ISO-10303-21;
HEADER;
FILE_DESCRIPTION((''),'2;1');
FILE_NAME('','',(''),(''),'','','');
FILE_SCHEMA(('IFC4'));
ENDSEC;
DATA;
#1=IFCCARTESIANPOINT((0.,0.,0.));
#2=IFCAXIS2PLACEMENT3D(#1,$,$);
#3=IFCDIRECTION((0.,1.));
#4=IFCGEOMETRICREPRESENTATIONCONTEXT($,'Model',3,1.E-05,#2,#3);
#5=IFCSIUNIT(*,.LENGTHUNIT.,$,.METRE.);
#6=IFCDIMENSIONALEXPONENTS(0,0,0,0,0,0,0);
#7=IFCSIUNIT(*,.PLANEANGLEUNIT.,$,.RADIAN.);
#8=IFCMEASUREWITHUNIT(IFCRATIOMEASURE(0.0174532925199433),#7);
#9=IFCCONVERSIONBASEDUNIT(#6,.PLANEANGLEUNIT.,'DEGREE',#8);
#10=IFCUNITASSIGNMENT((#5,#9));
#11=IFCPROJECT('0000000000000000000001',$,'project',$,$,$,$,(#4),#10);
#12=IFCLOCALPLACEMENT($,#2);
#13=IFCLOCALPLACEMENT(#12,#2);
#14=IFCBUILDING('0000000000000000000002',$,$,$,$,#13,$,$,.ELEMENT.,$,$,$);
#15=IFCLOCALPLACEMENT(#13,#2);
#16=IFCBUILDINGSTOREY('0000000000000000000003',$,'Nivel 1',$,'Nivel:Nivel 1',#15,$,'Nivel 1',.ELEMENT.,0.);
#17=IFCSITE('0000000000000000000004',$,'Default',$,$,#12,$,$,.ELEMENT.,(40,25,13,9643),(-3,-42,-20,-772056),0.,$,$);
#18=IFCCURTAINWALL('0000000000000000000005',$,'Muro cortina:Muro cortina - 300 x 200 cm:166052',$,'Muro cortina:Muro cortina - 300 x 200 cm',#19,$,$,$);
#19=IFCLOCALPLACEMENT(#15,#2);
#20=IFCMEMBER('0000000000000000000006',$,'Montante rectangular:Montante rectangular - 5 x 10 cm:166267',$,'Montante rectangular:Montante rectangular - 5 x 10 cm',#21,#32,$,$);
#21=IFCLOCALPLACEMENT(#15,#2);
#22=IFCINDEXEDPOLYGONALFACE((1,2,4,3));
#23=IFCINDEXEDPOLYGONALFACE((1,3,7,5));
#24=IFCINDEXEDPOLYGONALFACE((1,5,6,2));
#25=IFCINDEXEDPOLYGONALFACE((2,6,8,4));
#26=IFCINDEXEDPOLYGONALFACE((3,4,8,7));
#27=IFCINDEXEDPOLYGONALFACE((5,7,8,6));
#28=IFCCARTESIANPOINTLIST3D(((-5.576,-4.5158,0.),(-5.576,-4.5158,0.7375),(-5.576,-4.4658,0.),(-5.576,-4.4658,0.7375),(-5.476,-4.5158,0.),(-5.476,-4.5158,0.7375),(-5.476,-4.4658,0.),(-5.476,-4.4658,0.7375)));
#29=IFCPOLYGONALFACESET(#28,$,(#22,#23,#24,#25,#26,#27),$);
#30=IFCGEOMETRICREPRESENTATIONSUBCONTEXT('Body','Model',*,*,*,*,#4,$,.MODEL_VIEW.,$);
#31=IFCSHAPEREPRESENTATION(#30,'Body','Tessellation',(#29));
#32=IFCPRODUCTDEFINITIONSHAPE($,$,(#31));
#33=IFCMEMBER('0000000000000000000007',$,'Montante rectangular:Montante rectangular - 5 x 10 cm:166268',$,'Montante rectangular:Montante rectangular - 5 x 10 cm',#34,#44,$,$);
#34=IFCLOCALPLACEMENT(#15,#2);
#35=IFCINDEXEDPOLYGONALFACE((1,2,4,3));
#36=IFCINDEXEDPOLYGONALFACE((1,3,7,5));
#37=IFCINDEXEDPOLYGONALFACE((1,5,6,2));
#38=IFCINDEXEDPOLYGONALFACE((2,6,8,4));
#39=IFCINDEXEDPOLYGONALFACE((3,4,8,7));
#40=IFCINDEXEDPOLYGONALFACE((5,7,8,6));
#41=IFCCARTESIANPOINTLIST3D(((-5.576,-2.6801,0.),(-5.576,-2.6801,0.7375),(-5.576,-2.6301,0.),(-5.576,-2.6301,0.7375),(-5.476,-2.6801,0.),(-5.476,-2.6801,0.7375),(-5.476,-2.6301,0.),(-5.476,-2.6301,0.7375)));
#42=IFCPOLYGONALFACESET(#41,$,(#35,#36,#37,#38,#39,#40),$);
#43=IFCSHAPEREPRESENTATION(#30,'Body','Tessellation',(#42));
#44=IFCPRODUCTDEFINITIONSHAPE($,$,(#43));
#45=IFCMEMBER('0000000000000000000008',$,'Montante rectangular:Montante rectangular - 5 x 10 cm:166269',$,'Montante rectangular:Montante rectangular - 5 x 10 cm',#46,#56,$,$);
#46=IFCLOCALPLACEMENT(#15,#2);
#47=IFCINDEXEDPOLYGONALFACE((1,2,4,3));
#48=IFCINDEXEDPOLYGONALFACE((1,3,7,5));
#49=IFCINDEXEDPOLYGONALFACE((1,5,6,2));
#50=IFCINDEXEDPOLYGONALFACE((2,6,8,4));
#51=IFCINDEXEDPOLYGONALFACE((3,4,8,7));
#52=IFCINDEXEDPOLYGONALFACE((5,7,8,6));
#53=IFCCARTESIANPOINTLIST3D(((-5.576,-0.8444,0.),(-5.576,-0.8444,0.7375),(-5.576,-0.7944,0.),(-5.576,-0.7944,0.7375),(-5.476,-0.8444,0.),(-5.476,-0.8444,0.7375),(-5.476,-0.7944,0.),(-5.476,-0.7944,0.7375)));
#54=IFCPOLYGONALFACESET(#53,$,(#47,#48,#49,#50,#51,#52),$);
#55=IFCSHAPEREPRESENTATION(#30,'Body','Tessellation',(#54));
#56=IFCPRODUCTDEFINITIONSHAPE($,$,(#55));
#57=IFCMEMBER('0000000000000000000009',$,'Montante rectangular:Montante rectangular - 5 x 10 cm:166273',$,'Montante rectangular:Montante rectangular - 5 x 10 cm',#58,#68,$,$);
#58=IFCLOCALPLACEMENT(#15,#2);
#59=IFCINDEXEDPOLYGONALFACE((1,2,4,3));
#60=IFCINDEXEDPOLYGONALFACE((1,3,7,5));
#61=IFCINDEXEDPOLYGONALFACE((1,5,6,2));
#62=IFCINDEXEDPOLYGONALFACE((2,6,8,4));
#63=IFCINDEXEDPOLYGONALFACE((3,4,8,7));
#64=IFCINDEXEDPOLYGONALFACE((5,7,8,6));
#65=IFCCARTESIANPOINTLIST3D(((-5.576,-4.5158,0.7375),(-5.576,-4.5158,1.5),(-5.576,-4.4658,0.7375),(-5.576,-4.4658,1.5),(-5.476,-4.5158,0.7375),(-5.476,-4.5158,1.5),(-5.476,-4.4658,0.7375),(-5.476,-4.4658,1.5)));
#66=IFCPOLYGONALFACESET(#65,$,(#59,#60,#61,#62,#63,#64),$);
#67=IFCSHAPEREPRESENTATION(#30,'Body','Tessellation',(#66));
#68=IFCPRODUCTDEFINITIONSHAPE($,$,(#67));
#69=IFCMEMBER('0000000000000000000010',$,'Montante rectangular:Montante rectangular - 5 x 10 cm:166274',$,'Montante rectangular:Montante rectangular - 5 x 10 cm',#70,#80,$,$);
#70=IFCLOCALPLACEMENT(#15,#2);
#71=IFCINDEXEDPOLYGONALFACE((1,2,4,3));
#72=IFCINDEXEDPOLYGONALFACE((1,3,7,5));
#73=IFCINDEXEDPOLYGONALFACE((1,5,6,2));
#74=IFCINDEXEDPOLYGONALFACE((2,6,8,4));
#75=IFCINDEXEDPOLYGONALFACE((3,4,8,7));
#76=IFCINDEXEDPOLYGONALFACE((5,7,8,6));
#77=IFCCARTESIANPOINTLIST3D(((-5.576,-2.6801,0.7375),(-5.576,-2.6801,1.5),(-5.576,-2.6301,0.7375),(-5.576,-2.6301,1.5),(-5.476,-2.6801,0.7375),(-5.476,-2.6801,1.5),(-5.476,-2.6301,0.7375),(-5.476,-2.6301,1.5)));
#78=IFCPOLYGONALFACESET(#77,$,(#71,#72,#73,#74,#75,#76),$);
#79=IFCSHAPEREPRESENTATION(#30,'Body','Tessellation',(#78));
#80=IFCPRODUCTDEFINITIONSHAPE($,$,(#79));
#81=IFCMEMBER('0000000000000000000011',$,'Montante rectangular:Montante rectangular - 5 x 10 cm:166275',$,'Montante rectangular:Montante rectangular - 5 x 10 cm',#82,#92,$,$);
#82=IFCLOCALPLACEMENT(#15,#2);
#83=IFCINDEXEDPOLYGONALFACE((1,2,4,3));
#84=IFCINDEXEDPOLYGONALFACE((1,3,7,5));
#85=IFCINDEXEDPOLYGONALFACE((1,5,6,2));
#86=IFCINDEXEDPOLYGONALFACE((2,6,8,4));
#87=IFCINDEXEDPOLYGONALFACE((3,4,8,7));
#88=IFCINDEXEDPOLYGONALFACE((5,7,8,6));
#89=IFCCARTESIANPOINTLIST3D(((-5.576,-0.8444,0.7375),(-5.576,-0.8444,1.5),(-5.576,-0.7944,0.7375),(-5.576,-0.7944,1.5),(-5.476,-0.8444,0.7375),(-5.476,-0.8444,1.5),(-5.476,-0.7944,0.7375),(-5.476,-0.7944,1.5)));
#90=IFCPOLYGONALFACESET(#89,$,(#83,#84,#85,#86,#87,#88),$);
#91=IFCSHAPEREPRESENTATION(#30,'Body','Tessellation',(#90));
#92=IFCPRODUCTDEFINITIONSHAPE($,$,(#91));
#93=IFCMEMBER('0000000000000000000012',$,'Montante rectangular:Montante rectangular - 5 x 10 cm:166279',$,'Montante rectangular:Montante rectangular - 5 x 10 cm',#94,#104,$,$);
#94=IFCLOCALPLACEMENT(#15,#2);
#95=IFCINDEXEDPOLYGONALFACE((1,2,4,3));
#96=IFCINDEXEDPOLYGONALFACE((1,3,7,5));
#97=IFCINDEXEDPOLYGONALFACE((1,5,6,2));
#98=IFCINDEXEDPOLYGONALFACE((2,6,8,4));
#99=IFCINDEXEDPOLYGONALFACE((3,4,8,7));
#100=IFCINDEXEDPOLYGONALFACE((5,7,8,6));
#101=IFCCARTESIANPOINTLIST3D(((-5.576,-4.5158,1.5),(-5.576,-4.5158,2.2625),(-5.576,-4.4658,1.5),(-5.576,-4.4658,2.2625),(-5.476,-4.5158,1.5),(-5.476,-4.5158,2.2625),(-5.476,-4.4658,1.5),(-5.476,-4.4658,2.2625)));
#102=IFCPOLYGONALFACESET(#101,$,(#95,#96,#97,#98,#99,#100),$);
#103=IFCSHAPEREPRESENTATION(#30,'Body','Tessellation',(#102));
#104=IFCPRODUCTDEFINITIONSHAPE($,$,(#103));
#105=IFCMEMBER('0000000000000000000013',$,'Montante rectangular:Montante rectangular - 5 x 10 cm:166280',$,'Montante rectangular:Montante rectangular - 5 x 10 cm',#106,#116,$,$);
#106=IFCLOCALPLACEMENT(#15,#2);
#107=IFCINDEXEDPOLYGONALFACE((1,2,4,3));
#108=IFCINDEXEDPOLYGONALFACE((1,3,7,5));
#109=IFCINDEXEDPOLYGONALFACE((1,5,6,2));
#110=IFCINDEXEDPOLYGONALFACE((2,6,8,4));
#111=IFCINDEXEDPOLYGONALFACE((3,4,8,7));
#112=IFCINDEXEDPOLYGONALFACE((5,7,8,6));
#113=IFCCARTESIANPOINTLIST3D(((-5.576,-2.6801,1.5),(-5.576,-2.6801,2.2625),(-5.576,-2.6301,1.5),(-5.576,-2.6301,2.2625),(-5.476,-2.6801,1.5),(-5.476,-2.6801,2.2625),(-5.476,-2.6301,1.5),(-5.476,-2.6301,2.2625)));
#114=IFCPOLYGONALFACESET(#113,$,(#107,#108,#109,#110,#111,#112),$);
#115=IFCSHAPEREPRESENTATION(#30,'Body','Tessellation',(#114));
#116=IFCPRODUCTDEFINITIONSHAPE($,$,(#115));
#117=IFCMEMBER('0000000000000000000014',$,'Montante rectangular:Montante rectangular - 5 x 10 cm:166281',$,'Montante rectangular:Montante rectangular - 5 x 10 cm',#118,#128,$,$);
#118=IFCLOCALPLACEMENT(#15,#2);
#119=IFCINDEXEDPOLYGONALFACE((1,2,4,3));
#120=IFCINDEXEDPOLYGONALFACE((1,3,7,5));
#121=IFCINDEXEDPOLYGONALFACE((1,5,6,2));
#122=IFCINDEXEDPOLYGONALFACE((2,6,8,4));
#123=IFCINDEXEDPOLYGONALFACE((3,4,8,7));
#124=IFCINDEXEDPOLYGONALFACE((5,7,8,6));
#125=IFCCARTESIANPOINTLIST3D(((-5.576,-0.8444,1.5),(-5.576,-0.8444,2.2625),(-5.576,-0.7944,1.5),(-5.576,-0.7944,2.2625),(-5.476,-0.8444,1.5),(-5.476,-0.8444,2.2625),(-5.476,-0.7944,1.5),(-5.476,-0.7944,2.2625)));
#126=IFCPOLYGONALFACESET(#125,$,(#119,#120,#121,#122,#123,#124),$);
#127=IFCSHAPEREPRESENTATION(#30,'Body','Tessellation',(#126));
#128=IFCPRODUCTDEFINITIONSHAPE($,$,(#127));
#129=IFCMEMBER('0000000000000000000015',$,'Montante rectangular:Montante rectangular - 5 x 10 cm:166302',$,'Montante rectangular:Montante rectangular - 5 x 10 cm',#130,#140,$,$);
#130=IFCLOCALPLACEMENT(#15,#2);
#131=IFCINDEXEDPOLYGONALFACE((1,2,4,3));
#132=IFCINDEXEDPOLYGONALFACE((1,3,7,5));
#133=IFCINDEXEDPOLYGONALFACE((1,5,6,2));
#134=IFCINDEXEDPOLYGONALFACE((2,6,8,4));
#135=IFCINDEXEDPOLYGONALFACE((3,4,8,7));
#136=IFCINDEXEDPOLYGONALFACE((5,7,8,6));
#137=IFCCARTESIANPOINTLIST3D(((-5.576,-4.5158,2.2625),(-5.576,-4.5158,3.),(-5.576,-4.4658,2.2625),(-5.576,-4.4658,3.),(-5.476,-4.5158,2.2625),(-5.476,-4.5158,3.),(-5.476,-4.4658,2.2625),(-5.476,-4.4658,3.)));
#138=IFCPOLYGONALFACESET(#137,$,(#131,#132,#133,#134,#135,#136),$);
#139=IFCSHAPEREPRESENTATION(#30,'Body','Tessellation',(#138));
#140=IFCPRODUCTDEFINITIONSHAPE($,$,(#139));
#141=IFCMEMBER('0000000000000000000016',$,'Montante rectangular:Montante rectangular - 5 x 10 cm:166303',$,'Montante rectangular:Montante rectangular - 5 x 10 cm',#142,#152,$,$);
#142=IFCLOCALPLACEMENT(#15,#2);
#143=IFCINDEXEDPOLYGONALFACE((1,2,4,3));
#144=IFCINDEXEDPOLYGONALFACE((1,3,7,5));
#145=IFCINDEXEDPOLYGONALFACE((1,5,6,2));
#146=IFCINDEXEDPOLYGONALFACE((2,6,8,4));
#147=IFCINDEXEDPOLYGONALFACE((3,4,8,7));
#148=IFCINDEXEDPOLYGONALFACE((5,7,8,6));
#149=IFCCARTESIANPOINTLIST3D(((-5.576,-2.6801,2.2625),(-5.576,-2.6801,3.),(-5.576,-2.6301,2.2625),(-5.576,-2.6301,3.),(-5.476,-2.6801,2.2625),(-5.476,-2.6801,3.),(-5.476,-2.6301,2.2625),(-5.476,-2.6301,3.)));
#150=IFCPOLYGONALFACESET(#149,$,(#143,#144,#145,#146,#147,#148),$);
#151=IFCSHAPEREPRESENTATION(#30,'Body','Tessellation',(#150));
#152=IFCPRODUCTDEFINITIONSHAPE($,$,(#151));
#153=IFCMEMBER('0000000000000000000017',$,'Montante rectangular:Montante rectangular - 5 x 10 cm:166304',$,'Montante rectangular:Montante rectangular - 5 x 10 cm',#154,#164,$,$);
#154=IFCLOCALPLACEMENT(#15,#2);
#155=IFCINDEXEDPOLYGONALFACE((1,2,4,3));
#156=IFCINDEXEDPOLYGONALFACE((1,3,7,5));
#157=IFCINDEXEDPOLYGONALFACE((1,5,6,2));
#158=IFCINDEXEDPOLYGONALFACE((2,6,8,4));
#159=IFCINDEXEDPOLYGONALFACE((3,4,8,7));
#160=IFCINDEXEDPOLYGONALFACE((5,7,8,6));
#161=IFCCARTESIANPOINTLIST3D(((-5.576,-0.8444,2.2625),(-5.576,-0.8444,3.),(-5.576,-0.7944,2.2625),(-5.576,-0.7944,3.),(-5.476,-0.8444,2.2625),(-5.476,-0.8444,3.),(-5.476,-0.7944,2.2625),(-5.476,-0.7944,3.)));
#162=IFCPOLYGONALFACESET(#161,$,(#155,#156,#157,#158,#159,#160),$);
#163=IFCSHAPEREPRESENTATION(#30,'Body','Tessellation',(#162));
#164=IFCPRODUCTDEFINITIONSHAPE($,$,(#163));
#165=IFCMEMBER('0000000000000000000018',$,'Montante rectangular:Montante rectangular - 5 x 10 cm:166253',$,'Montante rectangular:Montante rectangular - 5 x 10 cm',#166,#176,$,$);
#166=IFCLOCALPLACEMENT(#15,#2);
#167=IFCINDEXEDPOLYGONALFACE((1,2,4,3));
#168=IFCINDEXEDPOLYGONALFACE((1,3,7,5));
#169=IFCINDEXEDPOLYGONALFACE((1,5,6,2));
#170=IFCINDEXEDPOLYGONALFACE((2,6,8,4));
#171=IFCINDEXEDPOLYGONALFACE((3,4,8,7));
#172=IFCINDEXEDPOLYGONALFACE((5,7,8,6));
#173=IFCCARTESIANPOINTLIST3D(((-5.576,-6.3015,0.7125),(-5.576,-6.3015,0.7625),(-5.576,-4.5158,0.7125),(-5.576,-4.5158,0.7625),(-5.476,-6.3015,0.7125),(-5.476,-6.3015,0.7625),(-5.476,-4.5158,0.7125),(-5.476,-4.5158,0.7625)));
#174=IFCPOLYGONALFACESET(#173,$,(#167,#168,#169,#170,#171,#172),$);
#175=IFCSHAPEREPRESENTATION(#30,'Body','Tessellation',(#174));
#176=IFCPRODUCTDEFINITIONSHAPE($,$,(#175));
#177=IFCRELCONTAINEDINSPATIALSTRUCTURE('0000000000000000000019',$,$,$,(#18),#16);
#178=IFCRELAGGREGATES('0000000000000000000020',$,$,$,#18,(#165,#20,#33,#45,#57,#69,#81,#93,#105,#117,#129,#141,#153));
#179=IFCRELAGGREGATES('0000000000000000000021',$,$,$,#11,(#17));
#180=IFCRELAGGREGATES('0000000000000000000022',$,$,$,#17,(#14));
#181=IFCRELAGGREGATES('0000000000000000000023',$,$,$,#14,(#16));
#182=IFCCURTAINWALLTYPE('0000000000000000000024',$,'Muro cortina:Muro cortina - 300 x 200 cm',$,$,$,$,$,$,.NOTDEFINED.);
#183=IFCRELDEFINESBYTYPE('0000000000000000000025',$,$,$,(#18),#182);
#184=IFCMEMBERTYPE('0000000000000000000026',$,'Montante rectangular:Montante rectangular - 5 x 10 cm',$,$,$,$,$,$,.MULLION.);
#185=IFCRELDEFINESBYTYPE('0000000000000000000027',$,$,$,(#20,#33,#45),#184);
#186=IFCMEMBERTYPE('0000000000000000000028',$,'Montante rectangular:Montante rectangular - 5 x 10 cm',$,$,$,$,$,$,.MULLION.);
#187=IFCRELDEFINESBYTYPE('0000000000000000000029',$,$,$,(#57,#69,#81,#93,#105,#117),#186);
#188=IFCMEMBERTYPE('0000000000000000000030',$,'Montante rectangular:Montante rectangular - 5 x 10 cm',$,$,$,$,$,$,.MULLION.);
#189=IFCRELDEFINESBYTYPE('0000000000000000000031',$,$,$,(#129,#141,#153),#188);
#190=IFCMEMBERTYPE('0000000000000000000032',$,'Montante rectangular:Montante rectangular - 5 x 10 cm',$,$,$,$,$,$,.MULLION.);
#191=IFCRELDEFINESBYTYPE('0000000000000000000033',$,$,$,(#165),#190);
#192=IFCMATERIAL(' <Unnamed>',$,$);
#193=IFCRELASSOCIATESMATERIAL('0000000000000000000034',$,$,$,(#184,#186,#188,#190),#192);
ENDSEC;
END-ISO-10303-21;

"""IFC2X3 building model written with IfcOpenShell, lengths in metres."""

from ifc_helpers import new_model, entity, si_unit, converted_unit, direction, frame, origin, origin_2d_with_axis, place, context, subcontext, project, spatial, rectangle, extrude, source, transform, mapped, material, type_object, type_shapes, element, aggregate, save


model = new_model("IFC2X3")

# Units and contexts
model_context = context("Model", 3, precision=1e-05, world=origin(), true_north=direction((0.0, 1.0)))
body_context = subcontext(model_context, "Body", "Model", "MODEL_VIEW")
ifc_project = project(units=[si_unit("LENGTHUNIT", "METRE"), converted_unit("PLANEANGLEUNIT", "DEGREE", entity("IfcRatioMeasure", 0.0174532925199433), si_unit("PLANEANGLEUNIT", "RADIAN"), dimensions=[0, 0, 0, 0, 0, 0, 0])], contexts=[model_context])

# Site, building, storey
site_placement = place(None, origin())
site = spatial("IfcSite", under=ifc_project, at=site_placement, Name="Default", CompositionType="ELEMENT", RefLatitude=(40, 25, 13, 9643), RefLongitude=(-3, -42, -20, -772056), RefElevation=0.0)
building_placement = place(site_placement, origin())
building = spatial("IfcBuilding", under=site, at=building_placement, CompositionType="ELEMENT")
storey_placement = place(building_placement, origin())
storey = spatial("IfcBuildingStorey", under=building, at=storey_placement, Name="Nivel 1", ObjectType="Nivel:Nivel 1", LongName="Nivel 1", CompositionType="ELEMENT", Elevation=0.0)

# Curtain wall, members
curtain_wall_type = type_object("IfcCurtainWallType", Name="Muro cortina:Muro cortina - 300 x 200 cm", PredefinedType="NOTDEFINED")
curtain_wall_placement = place(storey_placement, origin())
curtain_wall = element("IfcCurtainWall", 1, at=curtain_wall_placement, inside=storey, type_object=curtain_wall_type, Name="Muro cortina:Muro cortina - 300 x 200 cm:166052", ObjectType="Muro cortina:Muro cortina - 300 x 200 cm")
ifc_material_1 = material(Name=" <Unnamed>")
member_type_1 = type_object("IfcMemberType", Name="Montante rectangular:Montante rectangular - 5 x 10 cm", PredefinedType="MULLION", material=ifc_material_1)
shared_shape_1 = source(origin(), body_context, "Body", "SweptSolid", [
    extrude(rectangle(XDim=0.1, YDim=0.05, at=origin_2d_with_axis()), frame((0.0, 0.0, -0.7375), z_axis=(0.0, 0.0, 1.0), x_axis=(0.0, -1.0, 0.0)), (0.0, 0.0, 1.0), 0.7375),
])
type_shapes(member_type_1, [shared_shape_1])
member_1_placement = place(storey_placement, frame((-5.526, -4.4908, 0.0), z_axis=(0.0, 0.0, -1.0), x_axis=(0.0, 1.0, 0.0)))
member_1 = element("IfcMember", 2, at=member_1_placement, type_object=member_type_1, Name="Montante rectangular:Montante rectangular - 5 x 10 cm:166267", ObjectType="Montante rectangular:Montante rectangular - 5 x 10 cm", context=body_context, shape_type="MappedRepresentation", body=[
    mapped(shared_shape_1, transform((0.0, 0.0, 0.0), scale=1.0)),
])
member_2_placement = place(storey_placement, frame((-5.526, -2.6551, 0.0), z_axis=(0.0, 0.0, -1.0), x_axis=(0.0, 1.0, 0.0)))
member_2 = element("IfcMember", 3, at=member_2_placement, type_object=member_type_1, Name="Montante rectangular:Montante rectangular - 5 x 10 cm:166268", ObjectType="Montante rectangular:Montante rectangular - 5 x 10 cm", context=body_context, shape_type="MappedRepresentation", body=[
    mapped(shared_shape_1, transform((0.0, 0.0, 0.0), scale=1.0)),
])
member_3_placement = place(storey_placement, frame((-5.526, -0.8194, 0.0), z_axis=(0.0, 0.0, -1.0), x_axis=(0.0, 1.0, 0.0)))
member_3 = element("IfcMember", 4, at=member_3_placement, type_object=member_type_1, Name="Montante rectangular:Montante rectangular - 5 x 10 cm:166269", ObjectType="Montante rectangular:Montante rectangular - 5 x 10 cm", context=body_context, shape_type="MappedRepresentation", body=[
    mapped(shared_shape_1, transform((0.0, 0.0, 0.0), scale=1.0)),
])
member_type_2 = type_object("IfcMemberType", Name="Montante rectangular:Montante rectangular - 5 x 10 cm", PredefinedType="MULLION", material=ifc_material_1)
shared_shape_2 = source(origin(), body_context, "Body", "SweptSolid", [
    extrude(rectangle(XDim=0.1, YDim=0.05, at=origin_2d_with_axis()), frame((0.0, 0.0, -0.7625), z_axis=(0.0, 0.0, 1.0), x_axis=(0.0, -1.0, 0.0)), (0.0, 0.0, 1.0), 0.7625),
])
type_shapes(member_type_2, [shared_shape_2])
member_4_placement = place(storey_placement, frame((-5.526, -4.4908, 0.7375), z_axis=(0.0, 0.0, -1.0), x_axis=(0.0, 1.0, 0.0)))
member_4 = element("IfcMember", 5, at=member_4_placement, type_object=member_type_2, Name="Montante rectangular:Montante rectangular - 5 x 10 cm:166273", ObjectType="Montante rectangular:Montante rectangular - 5 x 10 cm", context=body_context, shape_type="MappedRepresentation", body=[
    mapped(shared_shape_2, transform((0.0, 0.0, 0.0), scale=1.0)),
])
member_5_placement = place(storey_placement, frame((-5.526, -2.6551, 0.7375), z_axis=(0.0, 0.0, -1.0), x_axis=(0.0, 1.0, 0.0)))
member_5 = element("IfcMember", 6, at=member_5_placement, type_object=member_type_2, Name="Montante rectangular:Montante rectangular - 5 x 10 cm:166274", ObjectType="Montante rectangular:Montante rectangular - 5 x 10 cm", context=body_context, shape_type="MappedRepresentation", body=[
    mapped(shared_shape_2, transform((0.0, 0.0, 0.0), scale=1.0)),
])
member_6_placement = place(storey_placement, frame((-5.526, -0.8194, 0.7375), z_axis=(0.0, 0.0, -1.0), x_axis=(0.0, 1.0, 0.0)))
member_6 = element("IfcMember", 7, at=member_6_placement, type_object=member_type_2, Name="Montante rectangular:Montante rectangular - 5 x 10 cm:166275", ObjectType="Montante rectangular:Montante rectangular - 5 x 10 cm", context=body_context, shape_type="MappedRepresentation", body=[
    mapped(shared_shape_2, transform((0.0, 0.0, 0.0), scale=1.0)),
])
member_7_placement = place(storey_placement, frame((-5.526, -4.4908, 1.5), z_axis=(0.0, 0.0, -1.0), x_axis=(0.0, 1.0, 0.0)))
member_7 = element("IfcMember", 8, at=member_7_placement, type_object=member_type_2, Name="Montante rectangular:Montante rectangular - 5 x 10 cm:166279", ObjectType="Montante rectangular:Montante rectangular - 5 x 10 cm", context=body_context, shape_type="MappedRepresentation", body=[
    mapped(shared_shape_2, transform((0.0, 0.0, 0.0), scale=1.0)),
])
member_8_placement = place(storey_placement, frame((-5.526, -2.6551, 1.5), z_axis=(0.0, 0.0, -1.0), x_axis=(0.0, 1.0, 0.0)))
member_8 = element("IfcMember", 9, at=member_8_placement, type_object=member_type_2, Name="Montante rectangular:Montante rectangular - 5 x 10 cm:166280", ObjectType="Montante rectangular:Montante rectangular - 5 x 10 cm", context=body_context, shape_type="MappedRepresentation", body=[
    mapped(shared_shape_2, transform((0.0, 0.0, 0.0), scale=1.0)),
])
member_9_placement = place(storey_placement, frame((-5.526, -0.8194, 1.5), z_axis=(0.0, 0.0, -1.0), x_axis=(0.0, 1.0, 0.0)))
member_9 = element("IfcMember", 10, at=member_9_placement, type_object=member_type_2, Name="Montante rectangular:Montante rectangular - 5 x 10 cm:166281", ObjectType="Montante rectangular:Montante rectangular - 5 x 10 cm", context=body_context, shape_type="MappedRepresentation", body=[
    mapped(shared_shape_2, transform((0.0, 0.0, 0.0), scale=1.0)),
])
member_type_3 = type_object("IfcMemberType", Name="Montante rectangular:Montante rectangular - 5 x 10 cm", PredefinedType="MULLION", material=ifc_material_1)
shared_shape_3 = source(origin(), body_context, "Body", "SweptSolid", [
    extrude(rectangle(XDim=0.1, YDim=0.05, at=origin_2d_with_axis()), frame((0.0, 0.0, -0.7375), z_axis=(0.0, 0.0, 1.0), x_axis=(0.0, -1.0, 0.0)), (0.0, 0.0, 1.0), 0.7375),
])
type_shapes(member_type_3, [shared_shape_3])
member_10_placement = place(storey_placement, frame((-5.526, -4.4908, 2.2625), z_axis=(0.0, 0.0, -1.0), x_axis=(0.0, 1.0, 0.0)))
member_10 = element("IfcMember", 11, at=member_10_placement, type_object=member_type_3, Name="Montante rectangular:Montante rectangular - 5 x 10 cm:166302", ObjectType="Montante rectangular:Montante rectangular - 5 x 10 cm", context=body_context, shape_type="MappedRepresentation", body=[
    mapped(shared_shape_3, transform((0.0, 0.0, 0.0), scale=1.0)),
])
member_11_placement = place(storey_placement, frame((-5.526, -2.6551, 2.2625), z_axis=(0.0, 0.0, -1.0), x_axis=(0.0, 1.0, 0.0)))
member_11 = element("IfcMember", 12, at=member_11_placement, type_object=member_type_3, Name="Montante rectangular:Montante rectangular - 5 x 10 cm:166303", ObjectType="Montante rectangular:Montante rectangular - 5 x 10 cm", context=body_context, shape_type="MappedRepresentation", body=[
    mapped(shared_shape_3, transform((0.0, 0.0, 0.0), scale=1.0)),
])
member_12_placement = place(storey_placement, frame((-5.526, -0.8194, 2.2625), z_axis=(0.0, 0.0, -1.0), x_axis=(0.0, 1.0, 0.0)))
member_12 = element("IfcMember", 13, at=member_12_placement, type_object=member_type_3, Name="Montante rectangular:Montante rectangular - 5 x 10 cm:166304", ObjectType="Montante rectangular:Montante rectangular - 5 x 10 cm", context=body_context, shape_type="MappedRepresentation", body=[
    mapped(shared_shape_3, transform((0.0, 0.0, 0.0), scale=1.0)),
])
member_type_4 = type_object("IfcMemberType", Name="Montante rectangular:Montante rectangular - 5 x 10 cm", PredefinedType="MULLION", material=ifc_material_1)
shared_shape_4 = source(origin(), body_context, "Body", "SweptSolid", [
    extrude(rectangle(XDim=0.1, YDim=0.05, at=origin_2d_with_axis()), frame((0.0, 0.0, -1.7857), z_axis=(0.0, 0.0, 1.0), x_axis=(0.0, -1.0, 0.0)), (0.0, 0.0, 1.0), 1.7857),
])
type_shapes(member_type_4, [shared_shape_4])
member_13_placement = place(storey_placement, frame((-5.526, -4.5158, 0.7375), z_axis=(0.0, 1.0, 0.0), x_axis=(0.0, 0.0, 1.0)))
member_13 = element("IfcMember", 14, at=member_13_placement, type_object=member_type_4, Name="Montante rectangular:Montante rectangular - 5 x 10 cm:166253", ObjectType="Montante rectangular:Montante rectangular - 5 x 10 cm", context=body_context, shape_type="MappedRepresentation", body=[
    mapped(shared_shape_4, transform((0.0, 0.0, 0.0), scale=1.0)),
])
aggregate(curtain_wall, [member_13, member_1, member_2, member_3, member_4, member_5, member_6, member_7, member_8, member_9, member_10, member_11, member_12])

save(model, "model.ifc")
